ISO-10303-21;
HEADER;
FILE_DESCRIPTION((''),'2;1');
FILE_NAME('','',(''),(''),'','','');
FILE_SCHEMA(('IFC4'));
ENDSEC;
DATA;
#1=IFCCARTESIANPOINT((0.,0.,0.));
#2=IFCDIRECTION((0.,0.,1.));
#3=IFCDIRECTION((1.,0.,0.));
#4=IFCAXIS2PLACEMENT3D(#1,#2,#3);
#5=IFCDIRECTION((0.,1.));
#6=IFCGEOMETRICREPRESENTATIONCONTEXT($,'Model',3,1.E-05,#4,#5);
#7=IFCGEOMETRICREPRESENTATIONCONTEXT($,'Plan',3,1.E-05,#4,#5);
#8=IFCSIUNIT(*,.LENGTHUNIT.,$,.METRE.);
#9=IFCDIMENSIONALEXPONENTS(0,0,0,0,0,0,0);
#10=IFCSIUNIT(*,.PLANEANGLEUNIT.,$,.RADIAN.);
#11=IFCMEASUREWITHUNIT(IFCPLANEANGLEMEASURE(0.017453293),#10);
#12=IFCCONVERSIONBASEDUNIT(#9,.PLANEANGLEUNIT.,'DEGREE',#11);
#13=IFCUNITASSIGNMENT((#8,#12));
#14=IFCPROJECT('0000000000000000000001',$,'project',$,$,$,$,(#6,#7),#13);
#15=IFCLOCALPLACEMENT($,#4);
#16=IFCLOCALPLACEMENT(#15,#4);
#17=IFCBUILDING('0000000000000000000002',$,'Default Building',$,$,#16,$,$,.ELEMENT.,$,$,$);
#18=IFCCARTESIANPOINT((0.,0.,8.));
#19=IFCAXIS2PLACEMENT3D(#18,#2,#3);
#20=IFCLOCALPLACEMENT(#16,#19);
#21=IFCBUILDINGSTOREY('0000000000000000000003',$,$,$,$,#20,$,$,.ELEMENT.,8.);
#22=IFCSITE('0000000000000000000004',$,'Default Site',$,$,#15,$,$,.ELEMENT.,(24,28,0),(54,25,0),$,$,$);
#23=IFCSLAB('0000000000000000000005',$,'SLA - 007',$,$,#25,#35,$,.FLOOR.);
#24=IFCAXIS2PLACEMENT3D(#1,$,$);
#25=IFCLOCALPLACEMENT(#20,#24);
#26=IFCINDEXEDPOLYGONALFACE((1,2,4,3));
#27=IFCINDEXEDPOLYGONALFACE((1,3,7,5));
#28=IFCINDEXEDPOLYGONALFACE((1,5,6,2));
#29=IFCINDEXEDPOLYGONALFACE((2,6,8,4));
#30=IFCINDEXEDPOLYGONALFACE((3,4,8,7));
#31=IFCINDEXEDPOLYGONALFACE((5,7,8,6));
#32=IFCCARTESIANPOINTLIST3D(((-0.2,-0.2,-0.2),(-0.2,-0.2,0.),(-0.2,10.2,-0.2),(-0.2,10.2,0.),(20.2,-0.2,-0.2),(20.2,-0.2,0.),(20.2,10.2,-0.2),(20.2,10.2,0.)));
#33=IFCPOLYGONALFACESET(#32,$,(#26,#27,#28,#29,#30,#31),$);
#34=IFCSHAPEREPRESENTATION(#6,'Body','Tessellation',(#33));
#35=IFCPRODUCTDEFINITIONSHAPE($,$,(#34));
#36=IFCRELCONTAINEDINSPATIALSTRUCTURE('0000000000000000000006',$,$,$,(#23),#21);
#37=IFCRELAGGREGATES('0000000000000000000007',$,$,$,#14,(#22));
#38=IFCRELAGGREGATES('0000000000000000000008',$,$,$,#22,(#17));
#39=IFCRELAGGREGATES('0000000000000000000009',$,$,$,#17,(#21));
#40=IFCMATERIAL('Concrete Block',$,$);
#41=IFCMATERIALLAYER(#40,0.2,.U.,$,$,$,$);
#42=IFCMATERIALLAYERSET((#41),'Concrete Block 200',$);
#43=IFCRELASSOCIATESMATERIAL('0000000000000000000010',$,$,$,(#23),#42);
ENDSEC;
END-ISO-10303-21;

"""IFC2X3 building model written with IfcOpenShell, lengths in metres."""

from ifc_helpers import new_model, entity, si_unit, converted_unit, direction, frame, origin_with_axes, place, context, project, spatial, polyline, outline, extrude, material, layer, layer_set, layer_usage, element, save


model = new_model("IFC2X3")

# Units and contexts
model_context = context("Model", 3, precision=1e-05, world=origin_with_axes(), true_north=direction((0.0, 1.0)))
plan_context = context("Plan", 3, precision=1e-05, world=origin_with_axes(), true_north=direction((0.0, 1.0)))
ifc_project = project(units=[si_unit("LENGTHUNIT", "METRE"), converted_unit("PLANEANGLEUNIT", "DEGREE", entity("IfcPlaneAngleMeasure", 0.017453293), si_unit("PLANEANGLEUNIT", "RADIAN"), dimensions=[0, 0, 0, 0, 0, 0, 0])], contexts=[model_context, plan_context])

# Site, building, storey
site_placement = place(None, origin_with_axes())
site = spatial("IfcSite", under=ifc_project, at=site_placement, Name="Default Site", CompositionType="ELEMENT", RefLatitude=(24, 28, 0), RefLongitude=(54, 25, 0))
building_placement = place(site_placement, origin_with_axes())
building = spatial("IfcBuilding", under=site, at=building_placement, Name="Default Building", CompositionType="ELEMENT")
storey_placement = place(building_placement, frame((0.0, 0.0, 8.0), z_axis=(0.0, 0.0, 1.0), x_axis=(1.0, 0.0, 0.0)))
storey = spatial("IfcBuildingStorey", under=building, at=storey_placement, CompositionType="ELEMENT", Elevation=8.0)

# Slab
ifc_material = material(Name="Concrete Block")
ifc_layer = layer(ifc_material, 0.2, ventilated="UNKNOWN")
ifc_layer_set = layer_set([ifc_layer], Name="Concrete Block 200")
ifc_layer_usage = layer_usage(ifc_layer_set, "AXIS3", "NEGATIVE", 0.2)
slab_placement = place(storey_placement, frame((-0.2, 10.2, -0.2), z_axis=(0.0, 0.0, 1.0), x_axis=(1.0, 0.0, 0.0)))
element("IfcSlab", 1, at=slab_placement, inside=storey, material=ifc_layer_usage, Name="SLA - 007", PredefinedType="FLOOR", context=model_context, shape_type="SweptSolid", body=[
    extrude(outline(polyline([(0.0, 0.0), (20.4, 0.0), (20.4, -10.4), (0.0, -10.4), (0.0, 0.0)])), origin_with_axes(), (0.0, 0.0, 1.0), 0.2),
])

save(model, "model.ifc")
